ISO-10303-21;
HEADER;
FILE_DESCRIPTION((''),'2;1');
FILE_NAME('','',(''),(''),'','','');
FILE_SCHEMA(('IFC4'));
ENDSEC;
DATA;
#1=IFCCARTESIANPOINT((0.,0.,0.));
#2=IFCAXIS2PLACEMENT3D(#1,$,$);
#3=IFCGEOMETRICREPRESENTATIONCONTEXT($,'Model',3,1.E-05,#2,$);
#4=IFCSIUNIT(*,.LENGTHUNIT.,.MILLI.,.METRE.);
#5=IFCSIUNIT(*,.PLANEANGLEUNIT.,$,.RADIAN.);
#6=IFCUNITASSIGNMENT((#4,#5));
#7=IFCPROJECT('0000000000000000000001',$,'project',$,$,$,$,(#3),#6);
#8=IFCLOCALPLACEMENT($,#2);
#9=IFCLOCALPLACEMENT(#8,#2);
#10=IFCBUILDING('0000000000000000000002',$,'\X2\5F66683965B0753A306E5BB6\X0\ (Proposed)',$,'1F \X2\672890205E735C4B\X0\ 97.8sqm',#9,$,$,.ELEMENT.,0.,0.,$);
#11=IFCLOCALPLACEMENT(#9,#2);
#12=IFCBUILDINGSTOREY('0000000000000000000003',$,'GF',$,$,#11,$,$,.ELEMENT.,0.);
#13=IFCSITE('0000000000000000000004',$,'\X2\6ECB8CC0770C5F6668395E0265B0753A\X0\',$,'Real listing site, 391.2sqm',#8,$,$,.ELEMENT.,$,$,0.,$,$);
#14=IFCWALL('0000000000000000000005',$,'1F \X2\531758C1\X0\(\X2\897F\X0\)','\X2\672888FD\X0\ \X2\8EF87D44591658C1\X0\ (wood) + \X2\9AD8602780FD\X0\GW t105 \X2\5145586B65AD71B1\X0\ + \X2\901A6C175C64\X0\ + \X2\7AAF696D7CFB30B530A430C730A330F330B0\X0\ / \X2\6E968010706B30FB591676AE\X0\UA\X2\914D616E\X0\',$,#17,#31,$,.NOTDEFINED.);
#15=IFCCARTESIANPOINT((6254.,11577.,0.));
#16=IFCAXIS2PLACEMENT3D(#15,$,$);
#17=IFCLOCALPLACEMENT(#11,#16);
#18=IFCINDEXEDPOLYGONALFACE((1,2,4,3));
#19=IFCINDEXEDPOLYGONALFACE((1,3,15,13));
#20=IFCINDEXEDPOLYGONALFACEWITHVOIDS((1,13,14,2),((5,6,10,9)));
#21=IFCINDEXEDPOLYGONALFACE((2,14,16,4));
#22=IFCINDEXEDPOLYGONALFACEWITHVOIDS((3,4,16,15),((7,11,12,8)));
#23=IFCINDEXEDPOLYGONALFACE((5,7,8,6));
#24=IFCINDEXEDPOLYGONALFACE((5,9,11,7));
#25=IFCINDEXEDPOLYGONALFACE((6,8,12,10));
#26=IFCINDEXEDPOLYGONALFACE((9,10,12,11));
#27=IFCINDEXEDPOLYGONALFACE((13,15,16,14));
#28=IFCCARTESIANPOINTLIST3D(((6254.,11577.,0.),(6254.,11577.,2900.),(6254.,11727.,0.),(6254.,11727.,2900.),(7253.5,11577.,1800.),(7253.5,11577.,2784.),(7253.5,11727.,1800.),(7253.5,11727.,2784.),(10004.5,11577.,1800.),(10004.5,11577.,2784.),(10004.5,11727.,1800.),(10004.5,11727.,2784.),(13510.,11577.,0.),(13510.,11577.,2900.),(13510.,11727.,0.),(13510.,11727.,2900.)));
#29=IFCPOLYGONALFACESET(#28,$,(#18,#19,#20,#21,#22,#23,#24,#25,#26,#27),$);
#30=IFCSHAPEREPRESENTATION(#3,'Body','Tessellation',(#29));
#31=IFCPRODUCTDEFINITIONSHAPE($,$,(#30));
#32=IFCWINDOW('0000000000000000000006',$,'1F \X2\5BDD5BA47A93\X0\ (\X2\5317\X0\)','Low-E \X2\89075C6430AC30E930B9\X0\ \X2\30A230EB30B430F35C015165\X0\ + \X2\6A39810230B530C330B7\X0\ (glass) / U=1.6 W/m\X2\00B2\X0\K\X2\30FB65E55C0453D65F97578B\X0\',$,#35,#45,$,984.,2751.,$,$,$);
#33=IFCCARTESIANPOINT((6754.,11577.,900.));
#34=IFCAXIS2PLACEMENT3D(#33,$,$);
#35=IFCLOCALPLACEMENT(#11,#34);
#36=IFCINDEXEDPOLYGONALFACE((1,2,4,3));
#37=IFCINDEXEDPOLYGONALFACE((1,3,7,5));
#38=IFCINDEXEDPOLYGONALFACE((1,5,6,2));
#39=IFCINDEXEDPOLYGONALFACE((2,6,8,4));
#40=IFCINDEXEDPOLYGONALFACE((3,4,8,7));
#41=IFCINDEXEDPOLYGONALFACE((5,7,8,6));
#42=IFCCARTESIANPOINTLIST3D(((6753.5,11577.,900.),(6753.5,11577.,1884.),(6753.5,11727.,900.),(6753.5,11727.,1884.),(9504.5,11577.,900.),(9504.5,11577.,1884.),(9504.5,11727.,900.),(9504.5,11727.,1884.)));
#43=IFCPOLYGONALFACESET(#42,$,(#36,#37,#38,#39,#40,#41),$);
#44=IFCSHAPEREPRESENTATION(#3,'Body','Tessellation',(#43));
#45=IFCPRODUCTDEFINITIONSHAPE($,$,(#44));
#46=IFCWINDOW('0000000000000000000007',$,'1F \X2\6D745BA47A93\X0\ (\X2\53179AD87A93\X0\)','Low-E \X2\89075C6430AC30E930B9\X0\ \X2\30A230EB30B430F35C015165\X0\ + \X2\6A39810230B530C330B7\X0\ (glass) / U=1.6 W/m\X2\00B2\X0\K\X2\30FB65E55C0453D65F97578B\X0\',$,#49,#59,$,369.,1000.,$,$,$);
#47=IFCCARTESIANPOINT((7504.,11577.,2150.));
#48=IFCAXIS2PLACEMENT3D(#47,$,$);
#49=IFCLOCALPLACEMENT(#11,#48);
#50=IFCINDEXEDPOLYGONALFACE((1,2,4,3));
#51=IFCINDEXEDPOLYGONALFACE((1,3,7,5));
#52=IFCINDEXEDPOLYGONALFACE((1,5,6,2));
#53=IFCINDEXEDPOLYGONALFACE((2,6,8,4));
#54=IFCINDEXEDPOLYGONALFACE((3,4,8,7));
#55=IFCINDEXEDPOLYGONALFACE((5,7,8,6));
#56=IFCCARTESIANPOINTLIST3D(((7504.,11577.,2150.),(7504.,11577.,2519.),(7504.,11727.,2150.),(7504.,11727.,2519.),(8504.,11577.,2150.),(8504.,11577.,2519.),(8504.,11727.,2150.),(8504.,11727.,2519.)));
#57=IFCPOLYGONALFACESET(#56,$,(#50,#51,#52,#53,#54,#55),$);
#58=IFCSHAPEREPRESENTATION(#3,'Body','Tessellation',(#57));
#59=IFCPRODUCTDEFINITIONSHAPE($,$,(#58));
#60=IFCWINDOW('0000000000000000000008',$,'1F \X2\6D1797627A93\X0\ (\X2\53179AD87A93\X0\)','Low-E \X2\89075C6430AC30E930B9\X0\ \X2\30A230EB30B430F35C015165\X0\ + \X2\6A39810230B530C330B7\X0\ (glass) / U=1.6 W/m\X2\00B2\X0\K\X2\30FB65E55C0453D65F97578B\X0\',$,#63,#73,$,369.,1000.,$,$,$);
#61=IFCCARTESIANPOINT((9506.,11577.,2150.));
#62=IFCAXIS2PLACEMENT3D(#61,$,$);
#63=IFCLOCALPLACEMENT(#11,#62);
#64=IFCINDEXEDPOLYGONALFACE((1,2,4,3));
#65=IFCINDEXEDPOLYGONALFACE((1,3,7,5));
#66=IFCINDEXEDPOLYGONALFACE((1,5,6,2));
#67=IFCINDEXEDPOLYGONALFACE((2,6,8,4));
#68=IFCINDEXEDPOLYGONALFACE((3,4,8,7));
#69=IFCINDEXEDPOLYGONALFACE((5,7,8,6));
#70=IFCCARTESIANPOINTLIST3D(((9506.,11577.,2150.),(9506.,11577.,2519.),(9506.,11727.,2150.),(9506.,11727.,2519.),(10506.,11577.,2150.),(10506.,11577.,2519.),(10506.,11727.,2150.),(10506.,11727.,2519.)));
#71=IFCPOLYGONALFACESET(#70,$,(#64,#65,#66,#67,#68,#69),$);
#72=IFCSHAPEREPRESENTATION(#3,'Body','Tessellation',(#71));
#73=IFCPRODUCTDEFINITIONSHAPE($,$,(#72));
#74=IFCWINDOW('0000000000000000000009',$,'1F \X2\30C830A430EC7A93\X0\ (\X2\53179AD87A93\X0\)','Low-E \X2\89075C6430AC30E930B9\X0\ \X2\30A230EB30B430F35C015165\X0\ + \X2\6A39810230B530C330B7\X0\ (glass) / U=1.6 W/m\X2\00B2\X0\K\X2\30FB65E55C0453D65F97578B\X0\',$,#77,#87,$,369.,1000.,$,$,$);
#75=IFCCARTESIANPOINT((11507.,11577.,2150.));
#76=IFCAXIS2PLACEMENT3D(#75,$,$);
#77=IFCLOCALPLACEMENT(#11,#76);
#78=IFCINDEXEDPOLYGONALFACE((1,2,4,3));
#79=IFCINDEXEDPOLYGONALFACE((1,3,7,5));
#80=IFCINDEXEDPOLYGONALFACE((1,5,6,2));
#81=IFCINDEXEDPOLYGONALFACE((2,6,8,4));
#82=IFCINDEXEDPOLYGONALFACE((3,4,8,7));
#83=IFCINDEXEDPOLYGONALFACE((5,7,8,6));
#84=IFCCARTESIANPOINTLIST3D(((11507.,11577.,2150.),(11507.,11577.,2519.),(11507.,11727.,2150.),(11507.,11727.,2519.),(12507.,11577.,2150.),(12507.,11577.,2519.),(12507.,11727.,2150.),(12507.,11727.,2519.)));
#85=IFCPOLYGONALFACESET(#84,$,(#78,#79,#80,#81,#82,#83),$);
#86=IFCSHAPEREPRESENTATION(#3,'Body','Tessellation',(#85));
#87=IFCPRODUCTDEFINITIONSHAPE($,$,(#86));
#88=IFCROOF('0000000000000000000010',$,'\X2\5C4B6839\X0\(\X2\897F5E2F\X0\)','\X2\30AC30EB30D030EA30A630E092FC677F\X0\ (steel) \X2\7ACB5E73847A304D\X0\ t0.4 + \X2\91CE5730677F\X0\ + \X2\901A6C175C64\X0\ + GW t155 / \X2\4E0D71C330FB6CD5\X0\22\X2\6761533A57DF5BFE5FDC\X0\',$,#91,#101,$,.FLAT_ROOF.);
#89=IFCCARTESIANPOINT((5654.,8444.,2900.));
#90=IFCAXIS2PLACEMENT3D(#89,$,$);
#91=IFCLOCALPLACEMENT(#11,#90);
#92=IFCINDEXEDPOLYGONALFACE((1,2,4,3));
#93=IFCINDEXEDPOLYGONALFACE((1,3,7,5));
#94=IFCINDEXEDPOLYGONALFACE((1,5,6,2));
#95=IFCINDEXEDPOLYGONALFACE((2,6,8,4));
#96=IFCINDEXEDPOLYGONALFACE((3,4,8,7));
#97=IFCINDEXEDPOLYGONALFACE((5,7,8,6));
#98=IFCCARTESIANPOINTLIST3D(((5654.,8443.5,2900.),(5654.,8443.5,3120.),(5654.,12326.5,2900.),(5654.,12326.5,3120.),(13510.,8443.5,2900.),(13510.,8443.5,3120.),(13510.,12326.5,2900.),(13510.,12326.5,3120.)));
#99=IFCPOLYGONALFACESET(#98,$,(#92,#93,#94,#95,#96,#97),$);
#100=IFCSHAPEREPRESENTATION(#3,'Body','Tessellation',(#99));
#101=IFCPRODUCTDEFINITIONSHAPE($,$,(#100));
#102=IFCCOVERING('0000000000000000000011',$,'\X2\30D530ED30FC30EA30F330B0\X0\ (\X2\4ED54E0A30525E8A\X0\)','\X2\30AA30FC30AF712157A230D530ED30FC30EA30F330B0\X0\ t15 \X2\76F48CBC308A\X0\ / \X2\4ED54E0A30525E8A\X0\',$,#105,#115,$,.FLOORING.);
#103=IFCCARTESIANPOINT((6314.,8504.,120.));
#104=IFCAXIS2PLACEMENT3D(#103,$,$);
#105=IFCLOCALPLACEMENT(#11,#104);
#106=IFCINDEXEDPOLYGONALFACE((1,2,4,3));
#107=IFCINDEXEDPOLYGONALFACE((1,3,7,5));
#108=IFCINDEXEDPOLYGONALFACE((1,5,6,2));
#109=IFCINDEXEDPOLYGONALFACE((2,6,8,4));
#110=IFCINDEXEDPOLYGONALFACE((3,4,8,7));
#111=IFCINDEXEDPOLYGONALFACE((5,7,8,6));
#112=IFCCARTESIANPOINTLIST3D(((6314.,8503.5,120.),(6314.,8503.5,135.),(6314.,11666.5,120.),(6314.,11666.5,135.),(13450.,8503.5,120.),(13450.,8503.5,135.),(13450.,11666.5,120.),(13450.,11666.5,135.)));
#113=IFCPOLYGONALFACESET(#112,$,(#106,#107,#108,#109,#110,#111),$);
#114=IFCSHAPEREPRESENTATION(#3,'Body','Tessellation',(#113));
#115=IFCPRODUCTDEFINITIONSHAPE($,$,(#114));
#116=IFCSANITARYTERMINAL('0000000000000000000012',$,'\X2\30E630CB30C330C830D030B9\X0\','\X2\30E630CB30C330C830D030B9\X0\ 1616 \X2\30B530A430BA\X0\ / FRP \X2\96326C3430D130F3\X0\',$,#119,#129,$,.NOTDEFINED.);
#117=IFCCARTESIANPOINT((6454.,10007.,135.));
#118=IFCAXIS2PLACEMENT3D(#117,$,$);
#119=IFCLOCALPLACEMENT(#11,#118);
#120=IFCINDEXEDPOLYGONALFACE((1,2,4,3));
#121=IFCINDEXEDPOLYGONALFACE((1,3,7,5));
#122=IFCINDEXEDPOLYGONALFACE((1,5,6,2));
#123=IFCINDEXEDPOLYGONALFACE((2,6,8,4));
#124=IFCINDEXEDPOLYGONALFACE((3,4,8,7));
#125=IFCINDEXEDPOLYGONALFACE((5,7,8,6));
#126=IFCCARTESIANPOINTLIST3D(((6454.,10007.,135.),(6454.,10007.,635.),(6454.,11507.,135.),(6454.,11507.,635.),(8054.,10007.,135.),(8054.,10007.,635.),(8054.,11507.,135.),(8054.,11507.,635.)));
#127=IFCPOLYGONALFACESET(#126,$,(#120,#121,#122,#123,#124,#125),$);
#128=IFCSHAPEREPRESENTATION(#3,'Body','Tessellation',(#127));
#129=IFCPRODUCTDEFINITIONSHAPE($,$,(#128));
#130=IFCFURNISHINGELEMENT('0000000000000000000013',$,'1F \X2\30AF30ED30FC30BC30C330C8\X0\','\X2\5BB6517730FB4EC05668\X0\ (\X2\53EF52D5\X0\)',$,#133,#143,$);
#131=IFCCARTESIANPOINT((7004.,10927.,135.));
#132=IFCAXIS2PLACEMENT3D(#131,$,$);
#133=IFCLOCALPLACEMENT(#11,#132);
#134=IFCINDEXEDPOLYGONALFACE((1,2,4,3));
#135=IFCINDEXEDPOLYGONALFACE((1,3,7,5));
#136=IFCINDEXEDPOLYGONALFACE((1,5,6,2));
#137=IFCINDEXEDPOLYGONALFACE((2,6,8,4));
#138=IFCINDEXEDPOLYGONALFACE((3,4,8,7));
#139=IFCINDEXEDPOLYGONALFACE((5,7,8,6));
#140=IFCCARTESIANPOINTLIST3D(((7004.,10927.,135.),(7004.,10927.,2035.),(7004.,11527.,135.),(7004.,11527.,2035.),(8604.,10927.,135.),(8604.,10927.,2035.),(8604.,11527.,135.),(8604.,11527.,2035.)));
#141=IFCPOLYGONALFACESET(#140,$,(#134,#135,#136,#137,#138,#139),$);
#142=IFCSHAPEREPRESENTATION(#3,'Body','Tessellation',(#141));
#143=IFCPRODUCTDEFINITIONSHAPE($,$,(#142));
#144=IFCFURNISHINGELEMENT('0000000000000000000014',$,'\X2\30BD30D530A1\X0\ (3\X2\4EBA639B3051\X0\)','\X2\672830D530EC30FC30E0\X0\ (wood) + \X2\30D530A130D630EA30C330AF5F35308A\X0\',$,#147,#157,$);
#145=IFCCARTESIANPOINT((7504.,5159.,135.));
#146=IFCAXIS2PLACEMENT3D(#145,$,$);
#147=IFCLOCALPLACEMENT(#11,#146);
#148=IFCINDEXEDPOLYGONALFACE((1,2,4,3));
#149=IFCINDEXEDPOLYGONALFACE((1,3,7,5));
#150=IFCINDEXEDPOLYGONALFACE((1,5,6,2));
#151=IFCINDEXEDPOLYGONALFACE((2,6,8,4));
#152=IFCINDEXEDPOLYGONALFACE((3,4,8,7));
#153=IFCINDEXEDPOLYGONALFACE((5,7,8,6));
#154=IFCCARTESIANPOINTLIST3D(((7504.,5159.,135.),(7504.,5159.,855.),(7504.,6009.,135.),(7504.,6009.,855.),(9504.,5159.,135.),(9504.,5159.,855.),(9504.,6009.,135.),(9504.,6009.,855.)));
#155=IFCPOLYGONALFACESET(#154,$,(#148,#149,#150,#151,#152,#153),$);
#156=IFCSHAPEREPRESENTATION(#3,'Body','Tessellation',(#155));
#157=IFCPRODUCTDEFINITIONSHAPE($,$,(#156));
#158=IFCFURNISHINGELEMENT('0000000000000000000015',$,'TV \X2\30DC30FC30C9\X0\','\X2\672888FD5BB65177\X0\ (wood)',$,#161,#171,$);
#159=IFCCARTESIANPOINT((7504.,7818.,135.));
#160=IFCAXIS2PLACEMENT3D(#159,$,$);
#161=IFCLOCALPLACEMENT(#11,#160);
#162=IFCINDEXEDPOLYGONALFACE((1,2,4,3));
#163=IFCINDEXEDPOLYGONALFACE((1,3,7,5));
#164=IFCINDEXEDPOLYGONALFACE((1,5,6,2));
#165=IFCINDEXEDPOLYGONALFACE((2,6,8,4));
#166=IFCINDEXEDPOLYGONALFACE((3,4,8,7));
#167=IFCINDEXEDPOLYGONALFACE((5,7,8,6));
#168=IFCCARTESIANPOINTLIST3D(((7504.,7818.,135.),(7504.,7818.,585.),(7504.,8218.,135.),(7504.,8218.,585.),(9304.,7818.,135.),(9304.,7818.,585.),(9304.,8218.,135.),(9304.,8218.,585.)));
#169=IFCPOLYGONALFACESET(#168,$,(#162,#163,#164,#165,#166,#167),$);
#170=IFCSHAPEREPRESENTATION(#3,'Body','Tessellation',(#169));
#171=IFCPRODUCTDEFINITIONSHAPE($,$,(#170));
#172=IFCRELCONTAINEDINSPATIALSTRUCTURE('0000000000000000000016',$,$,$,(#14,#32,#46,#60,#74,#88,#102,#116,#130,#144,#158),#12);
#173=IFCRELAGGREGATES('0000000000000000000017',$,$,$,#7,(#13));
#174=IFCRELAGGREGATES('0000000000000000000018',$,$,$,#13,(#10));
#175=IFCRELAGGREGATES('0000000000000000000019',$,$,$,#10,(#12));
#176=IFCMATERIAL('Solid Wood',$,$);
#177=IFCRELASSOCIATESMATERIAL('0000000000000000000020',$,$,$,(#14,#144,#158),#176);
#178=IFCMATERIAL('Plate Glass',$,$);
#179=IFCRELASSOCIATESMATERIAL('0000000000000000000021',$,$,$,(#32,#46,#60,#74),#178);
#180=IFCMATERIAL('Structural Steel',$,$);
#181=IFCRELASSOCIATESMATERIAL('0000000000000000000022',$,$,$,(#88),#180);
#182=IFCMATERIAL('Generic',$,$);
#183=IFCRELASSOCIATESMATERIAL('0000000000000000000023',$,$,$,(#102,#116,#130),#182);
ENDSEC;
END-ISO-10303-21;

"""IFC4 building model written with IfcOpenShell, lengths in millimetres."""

from ifc_helpers import new_model, si_unit, frame, frame_2d, origin, place, context, project, spatial, rectangle, extrude, material, element, fill, save


model = new_model("IFC4")

# Units and contexts
model_context = context("Model", 3, precision=1e-05, world=origin())
ifc_project = project(units=[si_unit("LENGTHUNIT", "METRE", prefix="MILLI"), si_unit("PLANEANGLEUNIT", "RADIAN")], contexts=[model_context])

# Site, building, storey
site_placement = place(None, origin())
site = spatial("IfcSite", under=ifc_project, at=site_placement, Name="滋賀県彦根市新町", ObjectType="Real listing site, 391.2sqm", CompositionType="ELEMENT", RefElevation=0.0)
building_placement = place(site_placement, origin())
building = spatial("IfcBuilding", under=site, at=building_placement, Name="彦根新町の家 (Proposed)", ObjectType="1F 木造平屋 97.8sqm", CompositionType="ELEMENT", ElevationOfRefHeight=0.0, ElevationOfTerrain=0.0)
storey_placement = place(building_placement, origin())
storey = spatial("IfcBuildingStorey", under=building, at=storey_placement, Name="GF", CompositionType="ELEMENT", Elevation=0.0)

# Shared definitions
ifc_material_1 = material(Name="Solid Wood")

# Shared definitions
ifc_material_2 = material(Name="Plate Glass")

# Wall, openings, windows
wall_1_placement = place(storey_placement, frame((6254.0, 11577.0, 0.0)))
wall_1 = element("IfcWall", 1, at=wall_1_placement, inside=storey, material=ifc_material_1, Name="1F 北壁(西)", Description="木製 軸組外壁 (wood) + 高性能GW t105 充填断熱 + 通気層 + 窯業系サイディング / 準耐火・外皮UA配慮", PredefinedType="NOTDEFINED", context=model_context, shape_type="SweptSolid", body=[
    extrude(rectangle(XDim=7256.0, YDim=150.0, at=frame_2d((3628.0, 75.0))), frame((6254.0, 11577.0, 0.0)), (0.0, 0.0, 1.0), 2900.0),
])
opening_1_placement = place(storey_placement, frame((6754.0, 11577.0, 900.0)))
opening_1 = element("IfcOpeningElement", 2, at=opening_1_placement, cuts=wall_1, PredefinedType="NOTDEFINED", context=model_context, shape_type="SweptSolid", body=[
    extrude(rectangle(XDim=2751.0, YDim=150.0, at=frame_2d((1375.0, 75.0))), frame((6754.0, 11577.0, 900.0)), (0.0, 0.0, 1.0), 984.0),
])
opening_2_placement = place(storey_placement, frame((7504.0, 11577.0, 2150.0)))
opening_2 = element("IfcOpeningElement", 3, at=opening_2_placement, cuts=wall_1, PredefinedType="NOTDEFINED", context=model_context, shape_type="SweptSolid", body=[
    extrude(rectangle(XDim=1000.0, YDim=150.0, at=frame_2d((500.0, 75.0))), frame((7504.0, 11577.0, 2150.0)), (0.0, 0.0, 1.0), 369.0),
])
opening_3_placement = place(storey_placement, frame((9506.0, 11577.0, 2150.0)))
opening_3 = element("IfcOpeningElement", 4, at=opening_3_placement, cuts=wall_1, PredefinedType="NOTDEFINED", context=model_context, shape_type="SweptSolid", body=[
    extrude(rectangle(XDim=1000.0, YDim=150.0, at=frame_2d((500.0, 75.0))), frame((9506.0, 11577.0, 2150.0)), (0.0, 0.0, 1.0), 369.0),
])
opening_4_placement = place(storey_placement, frame((11507.0, 11577.0, 2150.0)))
opening_4 = element("IfcOpeningElement", 5, at=opening_4_placement, cuts=wall_1, PredefinedType="NOTDEFINED", context=model_context, shape_type="SweptSolid", body=[
    extrude(rectangle(XDim=1000.0, YDim=150.0, at=frame_2d((500.0, 75.0))), frame((11507.0, 11577.0, 2150.0)), (0.0, 0.0, 1.0), 369.0),
])
window_1_placement = place(storey_placement, frame((6754.0, 11577.0, 900.0)))
window_1 = element("IfcWindow", 6, at=window_1_placement, inside=storey, material=ifc_material_2, Name="1F 寝室窓 (北)", Description="Low-E 複層ガラス アルゴン封入 + 樹脂サッシ (glass) / U=1.6 W/m²K・日射取得型", OverallHeight=984.0, OverallWidth=2751.0, context=model_context, shape_type="SweptSolid", body=[
    extrude(rectangle(XDim=2751.0, YDim=150.0, at=frame_2d((1375.0, 75.0))), frame((6754.0, 11577.0, 900.0)), (0.0, 0.0, 1.0), 984.0),
])
fill(opening_1, window_1)
window_2_placement = place(storey_placement, frame((7504.0, 11577.0, 2150.0)))
window_2 = element("IfcWindow", 7, at=window_2_placement, inside=storey, material=ifc_material_2, Name="1F 浴室窓 (北高窓)", Description="Low-E 複層ガラス アルゴン封入 + 樹脂サッシ (glass) / U=1.6 W/m²K・日射取得型", OverallHeight=369.0, OverallWidth=1000.0, context=model_context, shape_type="SweptSolid", body=[
    extrude(rectangle(XDim=1000.0, YDim=150.0, at=frame_2d((500.0, 75.0))), frame((7504.0, 11577.0, 2150.0)), (0.0, 0.0, 1.0), 369.0),
])
fill(opening_2, window_2)
window_3_placement = place(storey_placement, frame((9506.0, 11577.0, 2150.0)))
window_3 = element("IfcWindow", 8, at=window_3_placement, inside=storey, material=ifc_material_2, Name="1F 洗面窓 (北高窓)", Description="Low-E 複層ガラス アルゴン封入 + 樹脂サッシ (glass) / U=1.6 W/m²K・日射取得型", OverallHeight=369.0, OverallWidth=1000.0, context=model_context, shape_type="SweptSolid", body=[
    extrude(rectangle(XDim=1000.0, YDim=150.0, at=frame_2d((500.0, 75.0))), frame((9506.0, 11577.0, 2150.0)), (0.0, 0.0, 1.0), 369.0),
])
fill(opening_3, window_3)
window_4_placement = place(storey_placement, frame((11507.0, 11577.0, 2150.0)))
window_4 = element("IfcWindow", 9, at=window_4_placement, inside=storey, material=ifc_material_2, Name="1F トイレ窓 (北高窓)", Description="Low-E 複層ガラス アルゴン封入 + 樹脂サッシ (glass) / U=1.6 W/m²K・日射取得型", OverallHeight=369.0, OverallWidth=1000.0, context=model_context, shape_type="SweptSolid", body=[
    extrude(rectangle(XDim=1000.0, YDim=150.0, at=frame_2d((500.0, 75.0))), frame((11507.0, 11577.0, 2150.0)), (0.0, 0.0, 1.0), 369.0),
])
fill(opening_4, window_4)

# Roof
ifc_material_3 = material(Name="Structural Steel")
roof_1_placement = place(storey_placement, frame((5654.0, 8444.0, 2900.0)))
element("IfcRoof", 10, at=roof_1_placement, inside=storey, material=ifc_material_3, Name="屋根(西帯)", Description="ガルバリウム鋼板 (steel) 立平葺き t0.4 + 野地板 + 通気層 + GW t155 / 不燃・法22条区域対応", PredefinedType="FLAT_ROOF", context=model_context, shape_type="SweptSolid", body=[
    extrude(rectangle(XDim=7856.0, YDim=3883.0, at=frame_2d((3928.0, 1941.0))), frame((5654.0, 8444.0, 2900.0)), (0.0, 0.0, 1.0), 220.0),
])

# Covering
ifc_material_4 = material(Name="Generic")
covering_1_placement = place(storey_placement, frame((6314.0, 8504.0, 120.0)))
element("IfcCovering", 11, at=covering_1_placement, inside=storey, material=ifc_material_4, Name="フローリング (仕上げ床)", Description="オーク無垢フローリング t15 直貼り / 仕上げ床", PredefinedType="FLOORING", context=model_context, shape_type="SweptSolid", body=[
    extrude(rectangle(XDim=7136.0, YDim=3163.0, at=frame_2d((3568.0, 1581.0))), frame((6314.0, 8504.0, 120.0)), (0.0, 0.0, 1.0), 15.0),
])

# Sanitary terminal
sanitary_terminal_placement = place(storey_placement, frame((6454.0, 10007.0, 135.0)))
element("IfcSanitaryTerminal", 12, at=sanitary_terminal_placement, inside=storey, material=ifc_material_4, Name="ユニットバス", Description="ユニットバス 1616 サイズ / FRP 防水パン", PredefinedType="NOTDEFINED", context=model_context, shape_type="SweptSolid", body=[
    extrude(rectangle(XDim=1600.0, YDim=1500.0, at=frame_2d((800.0, 750.0))), frame((6454.0, 10007.0, 135.0)), (0.0, 0.0, 1.0), 500.0),
])

# Furnishing elements
furnishing_1_placement = place(storey_placement, frame((7004.0, 10927.0, 135.0)))
element("IfcFurnishingElement", 13, at=furnishing_1_placement, inside=storey, material=ifc_material_4, Name="1F クローゼット", Description="家具・什器 (可動)", context=model_context, shape_type="SweptSolid", body=[
    extrude(rectangle(XDim=1600.0, YDim=600.0, at=frame_2d((800.0, 300.0))), frame((7004.0, 10927.0, 135.0)), (0.0, 0.0, 1.0), 1900.0),
])
furnishing_2_placement = place(storey_placement, frame((7504.0, 5159.0, 135.0)))
element("IfcFurnishingElement", 14, at=furnishing_2_placement, inside=storey, material=ifc_material_1, Name="ソファ (3人掛け)", Description="木フレーム (wood) + ファブリック張り", context=model_context, shape_type="SweptSolid", body=[
    extrude(rectangle(XDim=2000.0, YDim=850.0, at=frame_2d((1000.0, 425.0))), frame((7504.0, 5159.0, 135.0)), (0.0, 0.0, 1.0), 720.0),
])
furnishing_3_placement = place(storey_placement, frame((7504.0, 7818.0, 135.0)))
element("IfcFurnishingElement", 15, at=furnishing_3_placement, inside=storey, material=ifc_material_1, Name="TV ボード", Description="木製家具 (wood)", context=model_context, shape_type="SweptSolid", body=[
    extrude(rectangle(XDim=1800.0, YDim=400.0, at=frame_2d((900.0, 200.0))), frame((7504.0, 7818.0, 135.0)), (0.0, 0.0, 1.0), 450.0),
])

save(model, "model.ifc")
